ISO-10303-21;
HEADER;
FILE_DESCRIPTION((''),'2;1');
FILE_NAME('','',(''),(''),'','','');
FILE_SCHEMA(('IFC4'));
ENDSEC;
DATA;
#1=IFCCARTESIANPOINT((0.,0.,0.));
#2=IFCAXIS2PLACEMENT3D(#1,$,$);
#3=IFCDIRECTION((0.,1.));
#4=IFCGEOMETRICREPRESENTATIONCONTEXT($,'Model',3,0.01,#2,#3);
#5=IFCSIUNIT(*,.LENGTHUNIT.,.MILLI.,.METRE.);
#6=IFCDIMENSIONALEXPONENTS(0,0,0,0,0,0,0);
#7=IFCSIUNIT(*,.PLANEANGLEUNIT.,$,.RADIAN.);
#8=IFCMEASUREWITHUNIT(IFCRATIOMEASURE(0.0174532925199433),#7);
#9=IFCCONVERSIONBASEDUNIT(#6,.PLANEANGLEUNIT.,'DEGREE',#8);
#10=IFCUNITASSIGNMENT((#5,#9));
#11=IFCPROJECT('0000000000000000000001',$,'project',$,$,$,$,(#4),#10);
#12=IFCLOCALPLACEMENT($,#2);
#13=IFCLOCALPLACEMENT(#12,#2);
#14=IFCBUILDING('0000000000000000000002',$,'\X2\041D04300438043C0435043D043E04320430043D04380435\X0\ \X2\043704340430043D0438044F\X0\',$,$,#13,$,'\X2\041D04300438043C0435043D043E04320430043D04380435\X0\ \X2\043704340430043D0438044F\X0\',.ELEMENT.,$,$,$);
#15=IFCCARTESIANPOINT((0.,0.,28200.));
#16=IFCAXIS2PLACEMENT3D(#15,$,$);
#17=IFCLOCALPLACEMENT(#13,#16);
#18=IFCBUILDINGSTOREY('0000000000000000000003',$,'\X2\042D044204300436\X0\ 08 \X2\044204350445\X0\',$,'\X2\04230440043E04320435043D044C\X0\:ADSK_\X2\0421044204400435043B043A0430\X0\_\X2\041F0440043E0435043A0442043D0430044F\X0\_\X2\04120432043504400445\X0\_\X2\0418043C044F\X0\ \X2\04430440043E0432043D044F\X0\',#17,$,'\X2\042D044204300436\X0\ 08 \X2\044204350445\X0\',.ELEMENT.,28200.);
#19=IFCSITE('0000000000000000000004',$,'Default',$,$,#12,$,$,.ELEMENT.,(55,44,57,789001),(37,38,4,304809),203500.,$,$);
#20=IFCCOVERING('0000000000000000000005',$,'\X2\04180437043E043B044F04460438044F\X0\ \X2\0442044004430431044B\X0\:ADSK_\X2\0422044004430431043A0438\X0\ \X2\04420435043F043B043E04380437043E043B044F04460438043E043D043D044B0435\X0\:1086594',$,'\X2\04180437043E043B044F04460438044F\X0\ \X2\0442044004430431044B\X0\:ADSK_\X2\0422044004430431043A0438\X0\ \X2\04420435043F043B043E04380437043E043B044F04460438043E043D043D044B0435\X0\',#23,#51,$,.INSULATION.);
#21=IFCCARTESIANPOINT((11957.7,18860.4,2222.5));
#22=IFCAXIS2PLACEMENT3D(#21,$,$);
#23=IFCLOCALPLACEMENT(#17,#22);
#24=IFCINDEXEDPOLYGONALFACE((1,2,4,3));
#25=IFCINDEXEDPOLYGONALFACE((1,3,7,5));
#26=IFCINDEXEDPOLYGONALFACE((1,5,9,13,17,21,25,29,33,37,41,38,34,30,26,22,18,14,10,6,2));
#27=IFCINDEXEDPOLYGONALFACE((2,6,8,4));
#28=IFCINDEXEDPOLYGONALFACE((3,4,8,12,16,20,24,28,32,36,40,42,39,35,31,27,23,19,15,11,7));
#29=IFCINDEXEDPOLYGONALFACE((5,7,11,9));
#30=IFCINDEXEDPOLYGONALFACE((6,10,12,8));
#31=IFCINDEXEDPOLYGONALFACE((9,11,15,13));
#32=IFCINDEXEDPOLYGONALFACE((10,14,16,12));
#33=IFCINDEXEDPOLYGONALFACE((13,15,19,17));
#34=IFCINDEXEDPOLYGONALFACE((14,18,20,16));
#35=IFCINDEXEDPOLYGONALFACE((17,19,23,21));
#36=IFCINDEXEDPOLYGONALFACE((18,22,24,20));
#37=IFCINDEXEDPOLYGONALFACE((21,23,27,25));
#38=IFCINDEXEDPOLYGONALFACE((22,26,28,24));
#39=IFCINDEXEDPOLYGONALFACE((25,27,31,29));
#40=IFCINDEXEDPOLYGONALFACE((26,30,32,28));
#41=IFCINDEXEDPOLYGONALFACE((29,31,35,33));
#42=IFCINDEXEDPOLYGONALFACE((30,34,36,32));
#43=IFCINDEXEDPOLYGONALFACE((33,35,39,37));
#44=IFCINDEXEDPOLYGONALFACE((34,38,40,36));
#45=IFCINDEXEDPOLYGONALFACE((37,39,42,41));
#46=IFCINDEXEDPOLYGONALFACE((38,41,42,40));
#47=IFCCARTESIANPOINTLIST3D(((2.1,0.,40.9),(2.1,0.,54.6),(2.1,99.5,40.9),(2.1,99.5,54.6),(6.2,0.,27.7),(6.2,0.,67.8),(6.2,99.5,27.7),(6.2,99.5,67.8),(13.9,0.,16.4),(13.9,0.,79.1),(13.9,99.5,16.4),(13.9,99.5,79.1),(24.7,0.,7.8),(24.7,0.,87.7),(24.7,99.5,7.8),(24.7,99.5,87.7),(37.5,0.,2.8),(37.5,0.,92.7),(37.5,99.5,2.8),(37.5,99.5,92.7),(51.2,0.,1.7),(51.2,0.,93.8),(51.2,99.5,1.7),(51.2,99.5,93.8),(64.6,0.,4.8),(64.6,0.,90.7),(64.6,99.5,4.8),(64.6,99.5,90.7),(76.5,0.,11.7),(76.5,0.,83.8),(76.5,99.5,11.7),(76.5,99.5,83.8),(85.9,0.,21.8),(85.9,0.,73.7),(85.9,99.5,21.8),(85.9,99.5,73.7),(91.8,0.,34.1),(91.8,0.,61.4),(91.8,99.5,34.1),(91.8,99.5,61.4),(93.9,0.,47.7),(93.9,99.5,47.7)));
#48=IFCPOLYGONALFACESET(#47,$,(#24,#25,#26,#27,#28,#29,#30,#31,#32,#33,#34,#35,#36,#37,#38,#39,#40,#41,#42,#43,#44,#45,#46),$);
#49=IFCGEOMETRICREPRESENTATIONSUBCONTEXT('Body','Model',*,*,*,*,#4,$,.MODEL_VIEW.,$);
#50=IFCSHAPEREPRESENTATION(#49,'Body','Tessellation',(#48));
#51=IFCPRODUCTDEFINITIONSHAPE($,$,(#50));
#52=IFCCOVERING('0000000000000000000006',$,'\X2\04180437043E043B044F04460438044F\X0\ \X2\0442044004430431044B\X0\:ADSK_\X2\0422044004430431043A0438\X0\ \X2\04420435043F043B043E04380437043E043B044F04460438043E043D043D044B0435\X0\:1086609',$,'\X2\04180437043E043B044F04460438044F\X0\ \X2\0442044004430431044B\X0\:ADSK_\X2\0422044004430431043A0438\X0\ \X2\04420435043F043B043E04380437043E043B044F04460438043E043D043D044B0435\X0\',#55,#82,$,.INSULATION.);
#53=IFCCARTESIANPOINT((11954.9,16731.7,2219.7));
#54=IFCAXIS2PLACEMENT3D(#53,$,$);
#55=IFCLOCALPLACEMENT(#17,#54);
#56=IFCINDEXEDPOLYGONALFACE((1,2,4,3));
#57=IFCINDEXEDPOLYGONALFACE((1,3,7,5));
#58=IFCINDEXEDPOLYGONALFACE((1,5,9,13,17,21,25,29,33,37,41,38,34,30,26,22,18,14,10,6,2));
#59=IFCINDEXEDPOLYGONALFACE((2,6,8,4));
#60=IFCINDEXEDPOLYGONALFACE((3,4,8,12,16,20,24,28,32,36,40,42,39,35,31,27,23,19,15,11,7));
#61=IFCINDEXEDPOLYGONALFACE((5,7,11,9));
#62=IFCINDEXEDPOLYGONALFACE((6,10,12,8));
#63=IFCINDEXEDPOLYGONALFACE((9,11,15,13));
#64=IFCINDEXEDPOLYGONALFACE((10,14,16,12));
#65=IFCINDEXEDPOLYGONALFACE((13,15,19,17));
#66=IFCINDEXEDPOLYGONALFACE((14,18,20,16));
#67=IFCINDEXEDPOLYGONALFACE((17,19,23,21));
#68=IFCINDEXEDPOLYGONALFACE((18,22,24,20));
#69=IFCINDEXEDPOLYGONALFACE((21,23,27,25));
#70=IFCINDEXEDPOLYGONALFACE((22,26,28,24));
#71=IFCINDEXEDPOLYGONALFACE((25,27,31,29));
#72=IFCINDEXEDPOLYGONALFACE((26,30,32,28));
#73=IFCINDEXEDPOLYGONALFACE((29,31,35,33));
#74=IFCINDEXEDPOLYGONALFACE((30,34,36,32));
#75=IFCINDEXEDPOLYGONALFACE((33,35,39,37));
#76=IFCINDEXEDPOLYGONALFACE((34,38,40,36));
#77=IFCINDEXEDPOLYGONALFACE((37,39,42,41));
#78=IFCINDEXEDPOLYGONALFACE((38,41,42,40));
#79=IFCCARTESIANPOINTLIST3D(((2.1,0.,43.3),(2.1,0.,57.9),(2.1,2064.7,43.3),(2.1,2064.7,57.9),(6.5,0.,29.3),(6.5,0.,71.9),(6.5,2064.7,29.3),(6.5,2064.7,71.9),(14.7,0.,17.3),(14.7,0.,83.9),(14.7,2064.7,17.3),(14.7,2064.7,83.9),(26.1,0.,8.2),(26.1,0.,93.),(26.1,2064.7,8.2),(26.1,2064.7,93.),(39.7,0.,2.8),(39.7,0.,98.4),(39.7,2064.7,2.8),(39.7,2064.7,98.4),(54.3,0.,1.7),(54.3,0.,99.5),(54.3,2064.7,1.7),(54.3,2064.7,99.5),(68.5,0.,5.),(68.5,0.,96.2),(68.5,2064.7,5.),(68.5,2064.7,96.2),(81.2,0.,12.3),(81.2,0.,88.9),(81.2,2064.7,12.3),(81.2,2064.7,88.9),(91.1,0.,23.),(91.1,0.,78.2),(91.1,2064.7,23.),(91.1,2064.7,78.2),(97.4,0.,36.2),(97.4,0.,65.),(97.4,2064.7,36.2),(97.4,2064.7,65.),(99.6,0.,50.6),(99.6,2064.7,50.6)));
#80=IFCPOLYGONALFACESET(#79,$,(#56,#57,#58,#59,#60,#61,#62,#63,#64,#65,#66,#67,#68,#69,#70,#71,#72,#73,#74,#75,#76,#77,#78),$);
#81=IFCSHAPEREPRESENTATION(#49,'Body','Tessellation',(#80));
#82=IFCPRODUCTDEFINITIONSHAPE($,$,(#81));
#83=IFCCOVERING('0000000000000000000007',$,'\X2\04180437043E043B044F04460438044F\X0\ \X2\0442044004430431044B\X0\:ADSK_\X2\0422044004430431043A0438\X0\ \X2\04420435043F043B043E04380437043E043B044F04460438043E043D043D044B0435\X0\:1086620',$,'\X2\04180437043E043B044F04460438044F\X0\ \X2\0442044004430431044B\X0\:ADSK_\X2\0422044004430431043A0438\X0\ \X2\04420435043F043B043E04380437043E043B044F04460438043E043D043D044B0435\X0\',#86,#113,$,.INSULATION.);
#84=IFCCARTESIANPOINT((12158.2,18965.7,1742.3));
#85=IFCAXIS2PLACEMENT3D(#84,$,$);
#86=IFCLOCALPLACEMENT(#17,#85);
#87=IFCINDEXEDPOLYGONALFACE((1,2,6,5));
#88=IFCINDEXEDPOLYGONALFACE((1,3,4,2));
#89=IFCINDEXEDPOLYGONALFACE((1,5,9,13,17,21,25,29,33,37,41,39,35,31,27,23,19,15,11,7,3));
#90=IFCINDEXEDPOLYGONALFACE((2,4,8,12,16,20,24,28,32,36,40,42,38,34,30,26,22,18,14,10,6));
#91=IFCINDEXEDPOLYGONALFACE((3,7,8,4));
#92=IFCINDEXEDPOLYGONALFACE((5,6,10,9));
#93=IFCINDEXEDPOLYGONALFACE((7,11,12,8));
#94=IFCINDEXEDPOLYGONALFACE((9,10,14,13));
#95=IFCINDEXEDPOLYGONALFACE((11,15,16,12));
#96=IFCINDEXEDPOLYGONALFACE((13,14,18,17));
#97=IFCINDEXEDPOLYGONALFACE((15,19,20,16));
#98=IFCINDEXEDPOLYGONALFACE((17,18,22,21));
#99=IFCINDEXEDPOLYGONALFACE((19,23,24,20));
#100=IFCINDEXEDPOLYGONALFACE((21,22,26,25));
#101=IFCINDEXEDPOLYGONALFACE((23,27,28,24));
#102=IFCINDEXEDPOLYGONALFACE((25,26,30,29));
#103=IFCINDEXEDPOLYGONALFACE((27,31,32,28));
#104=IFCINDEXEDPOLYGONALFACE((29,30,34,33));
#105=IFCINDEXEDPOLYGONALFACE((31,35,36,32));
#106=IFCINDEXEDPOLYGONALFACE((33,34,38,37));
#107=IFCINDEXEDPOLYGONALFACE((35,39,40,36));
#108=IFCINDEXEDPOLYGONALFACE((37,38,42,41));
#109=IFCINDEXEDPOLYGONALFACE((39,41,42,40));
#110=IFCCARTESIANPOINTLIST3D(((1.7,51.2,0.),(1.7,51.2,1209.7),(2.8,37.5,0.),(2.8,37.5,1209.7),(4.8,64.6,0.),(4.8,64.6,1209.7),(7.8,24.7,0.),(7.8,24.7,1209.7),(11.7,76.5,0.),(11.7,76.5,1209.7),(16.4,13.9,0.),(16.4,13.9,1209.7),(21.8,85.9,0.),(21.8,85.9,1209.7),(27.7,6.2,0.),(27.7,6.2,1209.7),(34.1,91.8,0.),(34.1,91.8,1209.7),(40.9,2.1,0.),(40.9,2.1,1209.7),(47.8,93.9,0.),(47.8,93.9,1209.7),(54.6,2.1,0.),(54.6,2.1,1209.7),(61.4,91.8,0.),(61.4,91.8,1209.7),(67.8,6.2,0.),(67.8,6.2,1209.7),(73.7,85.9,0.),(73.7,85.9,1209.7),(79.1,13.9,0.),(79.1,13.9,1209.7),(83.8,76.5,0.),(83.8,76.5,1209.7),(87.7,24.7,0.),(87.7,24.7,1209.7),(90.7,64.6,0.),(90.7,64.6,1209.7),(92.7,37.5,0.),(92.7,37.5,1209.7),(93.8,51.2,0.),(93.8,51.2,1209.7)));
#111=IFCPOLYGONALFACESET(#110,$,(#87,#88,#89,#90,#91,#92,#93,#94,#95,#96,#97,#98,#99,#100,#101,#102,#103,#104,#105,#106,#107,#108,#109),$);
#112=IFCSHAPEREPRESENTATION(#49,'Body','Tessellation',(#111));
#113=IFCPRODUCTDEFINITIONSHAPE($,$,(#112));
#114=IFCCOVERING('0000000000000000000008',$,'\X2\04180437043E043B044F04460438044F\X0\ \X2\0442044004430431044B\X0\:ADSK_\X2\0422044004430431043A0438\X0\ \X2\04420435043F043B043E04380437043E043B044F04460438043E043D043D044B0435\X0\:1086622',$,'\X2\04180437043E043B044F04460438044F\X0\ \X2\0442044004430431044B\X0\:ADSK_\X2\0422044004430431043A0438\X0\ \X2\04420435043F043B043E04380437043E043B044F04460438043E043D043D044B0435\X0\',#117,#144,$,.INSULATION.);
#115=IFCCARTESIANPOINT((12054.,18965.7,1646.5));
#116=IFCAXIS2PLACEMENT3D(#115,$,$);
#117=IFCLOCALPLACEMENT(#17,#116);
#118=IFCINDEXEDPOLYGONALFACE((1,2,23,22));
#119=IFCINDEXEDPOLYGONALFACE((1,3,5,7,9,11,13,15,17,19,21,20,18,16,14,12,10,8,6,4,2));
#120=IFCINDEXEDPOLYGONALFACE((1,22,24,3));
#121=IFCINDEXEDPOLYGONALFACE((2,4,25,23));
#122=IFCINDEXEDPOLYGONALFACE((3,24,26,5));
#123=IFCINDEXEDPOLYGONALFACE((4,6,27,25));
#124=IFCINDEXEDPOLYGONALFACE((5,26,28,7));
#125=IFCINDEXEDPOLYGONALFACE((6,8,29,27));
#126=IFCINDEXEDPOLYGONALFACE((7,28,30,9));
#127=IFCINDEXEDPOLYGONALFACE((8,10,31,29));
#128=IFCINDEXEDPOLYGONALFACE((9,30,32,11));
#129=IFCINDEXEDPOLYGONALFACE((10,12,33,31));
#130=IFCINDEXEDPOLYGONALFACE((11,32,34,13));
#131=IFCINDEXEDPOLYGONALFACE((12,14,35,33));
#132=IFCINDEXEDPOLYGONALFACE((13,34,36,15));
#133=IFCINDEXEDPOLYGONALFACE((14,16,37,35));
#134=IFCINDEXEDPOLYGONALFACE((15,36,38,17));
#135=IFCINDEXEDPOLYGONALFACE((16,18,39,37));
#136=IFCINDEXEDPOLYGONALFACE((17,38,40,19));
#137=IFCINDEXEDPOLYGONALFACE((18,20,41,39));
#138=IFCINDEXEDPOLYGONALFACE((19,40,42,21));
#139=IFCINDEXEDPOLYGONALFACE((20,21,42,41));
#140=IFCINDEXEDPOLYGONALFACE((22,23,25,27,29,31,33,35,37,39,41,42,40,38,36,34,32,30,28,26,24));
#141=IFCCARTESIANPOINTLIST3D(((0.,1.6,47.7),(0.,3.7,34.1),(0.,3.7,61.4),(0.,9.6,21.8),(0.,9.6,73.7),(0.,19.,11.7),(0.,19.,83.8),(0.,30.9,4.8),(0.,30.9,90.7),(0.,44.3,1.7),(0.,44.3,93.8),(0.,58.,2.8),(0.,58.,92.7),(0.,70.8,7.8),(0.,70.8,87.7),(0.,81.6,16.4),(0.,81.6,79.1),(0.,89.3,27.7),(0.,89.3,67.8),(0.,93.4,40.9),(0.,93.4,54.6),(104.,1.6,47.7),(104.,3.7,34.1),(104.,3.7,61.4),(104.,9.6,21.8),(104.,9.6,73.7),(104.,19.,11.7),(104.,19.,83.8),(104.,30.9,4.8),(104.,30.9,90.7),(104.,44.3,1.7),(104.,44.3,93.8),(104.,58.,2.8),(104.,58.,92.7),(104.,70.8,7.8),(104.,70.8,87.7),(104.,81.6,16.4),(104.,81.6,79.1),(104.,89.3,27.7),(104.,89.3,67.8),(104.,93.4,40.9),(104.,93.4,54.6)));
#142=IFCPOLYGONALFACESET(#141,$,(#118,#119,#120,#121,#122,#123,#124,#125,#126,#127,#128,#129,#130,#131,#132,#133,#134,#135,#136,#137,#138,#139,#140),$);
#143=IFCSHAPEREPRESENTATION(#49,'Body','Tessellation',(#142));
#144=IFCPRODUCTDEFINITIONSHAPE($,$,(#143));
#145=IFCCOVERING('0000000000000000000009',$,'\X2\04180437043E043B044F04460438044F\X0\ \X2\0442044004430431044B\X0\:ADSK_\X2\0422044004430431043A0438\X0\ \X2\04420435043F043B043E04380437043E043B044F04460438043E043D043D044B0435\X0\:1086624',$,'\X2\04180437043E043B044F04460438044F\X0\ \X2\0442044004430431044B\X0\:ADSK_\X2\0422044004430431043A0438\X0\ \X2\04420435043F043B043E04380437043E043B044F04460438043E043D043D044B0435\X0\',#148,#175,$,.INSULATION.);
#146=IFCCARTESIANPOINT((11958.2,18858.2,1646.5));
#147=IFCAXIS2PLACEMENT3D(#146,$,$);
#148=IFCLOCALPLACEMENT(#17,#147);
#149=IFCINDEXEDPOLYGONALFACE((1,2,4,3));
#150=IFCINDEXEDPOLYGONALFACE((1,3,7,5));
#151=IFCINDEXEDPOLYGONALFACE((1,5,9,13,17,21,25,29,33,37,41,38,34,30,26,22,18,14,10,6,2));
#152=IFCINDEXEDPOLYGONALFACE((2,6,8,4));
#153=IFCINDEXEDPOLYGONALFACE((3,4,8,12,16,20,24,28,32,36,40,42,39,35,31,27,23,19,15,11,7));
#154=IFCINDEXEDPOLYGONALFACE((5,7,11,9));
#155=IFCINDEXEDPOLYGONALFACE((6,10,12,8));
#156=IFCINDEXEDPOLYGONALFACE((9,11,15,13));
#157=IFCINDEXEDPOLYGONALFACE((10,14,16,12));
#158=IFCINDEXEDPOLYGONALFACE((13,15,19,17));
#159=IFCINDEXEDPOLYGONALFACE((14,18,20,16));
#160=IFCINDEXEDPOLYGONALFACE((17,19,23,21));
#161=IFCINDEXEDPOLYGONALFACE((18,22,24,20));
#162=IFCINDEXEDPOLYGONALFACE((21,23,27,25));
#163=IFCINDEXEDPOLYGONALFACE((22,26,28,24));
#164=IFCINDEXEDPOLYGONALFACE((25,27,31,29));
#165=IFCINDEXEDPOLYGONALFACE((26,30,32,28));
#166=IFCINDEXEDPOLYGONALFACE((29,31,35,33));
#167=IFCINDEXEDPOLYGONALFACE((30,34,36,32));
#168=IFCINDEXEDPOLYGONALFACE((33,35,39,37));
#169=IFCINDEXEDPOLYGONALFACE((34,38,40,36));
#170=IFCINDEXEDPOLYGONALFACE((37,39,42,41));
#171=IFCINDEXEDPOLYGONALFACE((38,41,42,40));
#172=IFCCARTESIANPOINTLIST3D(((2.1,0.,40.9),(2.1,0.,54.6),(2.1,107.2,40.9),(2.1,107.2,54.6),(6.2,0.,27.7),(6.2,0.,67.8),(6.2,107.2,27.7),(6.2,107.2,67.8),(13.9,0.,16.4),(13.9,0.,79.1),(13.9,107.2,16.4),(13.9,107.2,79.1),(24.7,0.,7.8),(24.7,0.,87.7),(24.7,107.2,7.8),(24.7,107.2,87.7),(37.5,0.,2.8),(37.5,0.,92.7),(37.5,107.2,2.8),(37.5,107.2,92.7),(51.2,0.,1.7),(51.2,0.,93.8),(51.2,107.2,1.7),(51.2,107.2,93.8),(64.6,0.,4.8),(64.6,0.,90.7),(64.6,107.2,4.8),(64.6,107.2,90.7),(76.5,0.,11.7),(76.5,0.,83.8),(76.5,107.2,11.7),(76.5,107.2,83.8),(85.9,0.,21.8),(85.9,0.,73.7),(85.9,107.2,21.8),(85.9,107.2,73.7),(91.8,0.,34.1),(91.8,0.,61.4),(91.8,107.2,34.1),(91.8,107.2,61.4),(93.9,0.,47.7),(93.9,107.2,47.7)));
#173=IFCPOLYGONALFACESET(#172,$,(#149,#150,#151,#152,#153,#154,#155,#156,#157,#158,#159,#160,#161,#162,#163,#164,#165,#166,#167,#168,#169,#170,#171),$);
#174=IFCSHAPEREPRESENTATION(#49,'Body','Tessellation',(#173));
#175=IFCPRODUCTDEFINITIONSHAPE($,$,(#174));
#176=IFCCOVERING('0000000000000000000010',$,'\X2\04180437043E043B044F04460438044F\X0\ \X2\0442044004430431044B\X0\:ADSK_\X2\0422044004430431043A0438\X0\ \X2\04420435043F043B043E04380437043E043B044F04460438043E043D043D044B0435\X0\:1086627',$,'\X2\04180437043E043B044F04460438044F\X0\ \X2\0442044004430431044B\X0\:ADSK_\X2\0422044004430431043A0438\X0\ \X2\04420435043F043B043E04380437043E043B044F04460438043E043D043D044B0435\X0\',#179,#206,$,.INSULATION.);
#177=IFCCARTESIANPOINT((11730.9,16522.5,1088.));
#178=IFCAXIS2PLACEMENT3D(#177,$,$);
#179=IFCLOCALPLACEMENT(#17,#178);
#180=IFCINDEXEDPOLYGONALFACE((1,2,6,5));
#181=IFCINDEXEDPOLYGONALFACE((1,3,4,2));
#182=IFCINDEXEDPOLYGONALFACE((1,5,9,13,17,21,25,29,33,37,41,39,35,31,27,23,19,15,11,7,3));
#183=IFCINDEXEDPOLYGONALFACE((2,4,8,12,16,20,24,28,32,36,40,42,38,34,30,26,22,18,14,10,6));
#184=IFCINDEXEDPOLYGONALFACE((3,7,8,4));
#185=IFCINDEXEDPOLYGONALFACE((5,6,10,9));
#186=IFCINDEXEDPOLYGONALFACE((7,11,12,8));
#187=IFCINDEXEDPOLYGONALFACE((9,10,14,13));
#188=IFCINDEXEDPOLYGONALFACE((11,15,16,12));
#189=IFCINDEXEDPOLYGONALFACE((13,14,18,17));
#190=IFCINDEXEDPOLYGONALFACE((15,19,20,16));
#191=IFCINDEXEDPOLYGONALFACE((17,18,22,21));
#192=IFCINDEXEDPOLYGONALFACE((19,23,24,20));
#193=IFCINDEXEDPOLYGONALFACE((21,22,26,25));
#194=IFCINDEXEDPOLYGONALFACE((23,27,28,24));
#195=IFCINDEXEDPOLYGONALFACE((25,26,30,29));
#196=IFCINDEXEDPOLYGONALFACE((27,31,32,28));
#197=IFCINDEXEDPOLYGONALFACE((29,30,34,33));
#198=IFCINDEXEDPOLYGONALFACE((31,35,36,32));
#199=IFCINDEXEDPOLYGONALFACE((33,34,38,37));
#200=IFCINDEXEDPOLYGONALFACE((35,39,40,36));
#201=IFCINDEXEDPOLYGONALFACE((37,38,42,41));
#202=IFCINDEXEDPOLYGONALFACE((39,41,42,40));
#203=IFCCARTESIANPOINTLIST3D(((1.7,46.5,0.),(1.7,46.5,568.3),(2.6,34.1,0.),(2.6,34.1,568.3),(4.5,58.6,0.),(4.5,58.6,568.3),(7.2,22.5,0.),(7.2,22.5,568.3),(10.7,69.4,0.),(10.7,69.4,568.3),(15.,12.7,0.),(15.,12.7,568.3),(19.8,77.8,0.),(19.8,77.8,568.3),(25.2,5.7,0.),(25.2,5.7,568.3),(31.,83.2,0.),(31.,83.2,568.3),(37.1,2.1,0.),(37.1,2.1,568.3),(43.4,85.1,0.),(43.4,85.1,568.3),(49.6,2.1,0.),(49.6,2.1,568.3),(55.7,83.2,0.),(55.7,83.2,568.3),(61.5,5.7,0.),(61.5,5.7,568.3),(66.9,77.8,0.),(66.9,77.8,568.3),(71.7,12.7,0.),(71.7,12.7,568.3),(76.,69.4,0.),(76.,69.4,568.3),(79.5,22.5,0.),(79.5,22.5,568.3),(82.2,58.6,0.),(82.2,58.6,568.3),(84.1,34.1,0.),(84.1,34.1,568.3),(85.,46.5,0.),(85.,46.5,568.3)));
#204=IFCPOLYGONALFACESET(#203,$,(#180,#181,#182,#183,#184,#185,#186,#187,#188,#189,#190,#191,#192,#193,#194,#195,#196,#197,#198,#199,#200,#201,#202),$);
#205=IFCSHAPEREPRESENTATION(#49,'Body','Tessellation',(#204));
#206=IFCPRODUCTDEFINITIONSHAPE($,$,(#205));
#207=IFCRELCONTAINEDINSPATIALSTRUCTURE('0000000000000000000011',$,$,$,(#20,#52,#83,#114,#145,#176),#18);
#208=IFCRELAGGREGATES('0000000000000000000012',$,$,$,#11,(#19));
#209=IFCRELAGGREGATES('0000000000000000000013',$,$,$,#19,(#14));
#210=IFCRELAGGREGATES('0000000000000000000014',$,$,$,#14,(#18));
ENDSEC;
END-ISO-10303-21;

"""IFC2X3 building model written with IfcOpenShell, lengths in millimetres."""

from ifc_helpers import new_model, entity, si_unit, converted_unit, direction, frame, origin, origin_2d_with_axis, place, context, subcontext, project, spatial, circle, extrude, element, save


model = new_model("IFC2X3")

# Units and contexts
model_context = context("Model", 3, precision=0.01, world=origin(), true_north=direction((0.0, 1.0)))
body_context = subcontext(model_context, "Body", "Model", "MODEL_VIEW")
ifc_project = project(units=[si_unit("LENGTHUNIT", "METRE", prefix="MILLI"), converted_unit("PLANEANGLEUNIT", "DEGREE", entity("IfcRatioMeasure", 0.0174532925199433), si_unit("PLANEANGLEUNIT", "RADIAN"), dimensions=[0, 0, 0, 0, 0, 0, 0])], contexts=[model_context])

# Site, building, storey
site_placement = place(None, origin())
site = spatial("IfcSite", under=ifc_project, at=site_placement, Name="Default", CompositionType="ELEMENT", RefLatitude=(55, 44, 57, 789001), RefLongitude=(37, 38, 4, 304809), RefElevation=203500.0)
building_placement = place(site_placement, origin())
building = spatial("IfcBuilding", under=site, at=building_placement, Name="Наименование здания", LongName="Наименование здания", CompositionType="ELEMENT")
storey_placement = place(building_placement, frame((0.0, 0.0, 28200.0)))
storey = spatial("IfcBuildingStorey", under=building, at=storey_placement, Name="Этаж 08 тех", ObjectType="Уровень:ADSK_Стрелка_Проектная_Вверх_Имя уровня", LongName="Этаж 08 тех", CompositionType="ELEMENT", Elevation=28200.0)

# Coverings
covering_1_placement = place(storey_placement, frame((11957.7, 18860.4, 2222.5)))
element("IfcCovering", 1, at=covering_1_placement, inside=storey, Name="Изоляция трубы:ADSK_Трубки теплоизоляционные:1086594", ObjectType="Изоляция трубы:ADSK_Трубки теплоизоляционные", PredefinedType="INSULATION", context=body_context, shape_type="SweptSolid", body=[
    extrude(circle(Radius=46.1, at=origin_2d_with_axis()), frame((47.8, 0.0, 47.8), z_axis=(0.0, 1.0, 0.0), x_axis=(1.0, 0.0, 0.0)), (0.0, 0.0, 1.0), 99.5),
])
covering_2_placement = place(storey_placement, frame((11954.9, 16731.7, 2219.7)))
element("IfcCovering", 2, at=covering_2_placement, inside=storey, Name="Изоляция трубы:ADSK_Трубки теплоизоляционные:1086609", ObjectType="Изоляция трубы:ADSK_Трубки теплоизоляционные", PredefinedType="INSULATION", context=body_context, shape_type="SweptSolid", body=[
    extrude(circle(Radius=49.0, at=origin_2d_with_axis()), frame((50.6, 0.0, 50.6), z_axis=(0.0, 1.0, 0.0), x_axis=(1.0, 0.0, 0.0)), (0.0, 0.0, 1.0), 2064.7),
])
covering_3_placement = place(storey_placement, frame((12158.2, 18965.7, 1742.3)))
element("IfcCovering", 3, at=covering_3_placement, inside=storey, Name="Изоляция трубы:ADSK_Трубки теплоизоляционные:1086620", ObjectType="Изоляция трубы:ADSK_Трубки теплоизоляционные", PredefinedType="INSULATION", context=body_context, shape_type="SweptSolid", body=[
    extrude(circle(Radius=46.1, at=origin_2d_with_axis()), frame((47.8, 47.8, 0.0), z_axis=(0.0, 0.0, 1.0), x_axis=(0.0, 1.0, 0.0)), (0.0, 0.0, 1.0), 1209.7),
])
covering_4_placement = place(storey_placement, frame((12054.0, 18965.7, 1646.5)))
element("IfcCovering", 4, at=covering_4_placement, inside=storey, Name="Изоляция трубы:ADSK_Трубки теплоизоляционные:1086622", ObjectType="Изоляция трубы:ADSK_Трубки теплоизоляционные", PredefinedType="INSULATION", context=body_context, shape_type="SweptSolid", body=[
    extrude(circle(Radius=46.1, at=origin_2d_with_axis()), frame((0.0, 47.8, 47.8), z_axis=(1.0, 0.0, 0.0), x_axis=(0.0, -1.0, 0.0)), (0.0, 0.0, 1.0), 104.0),
])
covering_5_placement = place(storey_placement, frame((11958.2, 18858.2, 1646.5)))
element("IfcCovering", 5, at=covering_5_placement, inside=storey, Name="Изоляция трубы:ADSK_Трубки теплоизоляционные:1086624", ObjectType="Изоляция трубы:ADSK_Трубки теплоизоляционные", PredefinedType="INSULATION", context=body_context, shape_type="SweptSolid", body=[
    extrude(circle(Radius=46.1, at=origin_2d_with_axis()), frame((47.8, 0.0, 47.8), z_axis=(0.0, 1.0, 0.0), x_axis=(1.0, 0.0, 0.0)), (0.0, 0.0, 1.0), 107.2),
])
covering_6_placement = place(storey_placement, frame((11730.9, 16522.5, 1088.0)))
element("IfcCovering", 6, at=covering_6_placement, inside=storey, Name="Изоляция трубы:ADSK_Трубки теплоизоляционные:1086627", ObjectType="Изоляция трубы:ADSK_Трубки теплоизоляционные", PredefinedType="INSULATION", context=body_context, shape_type="SweptSolid", body=[
    extrude(circle(Radius=41.8, at=origin_2d_with_axis()), frame((43.4, 43.4, 0.0), z_axis=(0.0, 0.0, 1.0), x_axis=(0.0, 1.0, 0.0)), (0.0, 0.0, 1.0), 568.3),
])

save(model, "model.ifc")
